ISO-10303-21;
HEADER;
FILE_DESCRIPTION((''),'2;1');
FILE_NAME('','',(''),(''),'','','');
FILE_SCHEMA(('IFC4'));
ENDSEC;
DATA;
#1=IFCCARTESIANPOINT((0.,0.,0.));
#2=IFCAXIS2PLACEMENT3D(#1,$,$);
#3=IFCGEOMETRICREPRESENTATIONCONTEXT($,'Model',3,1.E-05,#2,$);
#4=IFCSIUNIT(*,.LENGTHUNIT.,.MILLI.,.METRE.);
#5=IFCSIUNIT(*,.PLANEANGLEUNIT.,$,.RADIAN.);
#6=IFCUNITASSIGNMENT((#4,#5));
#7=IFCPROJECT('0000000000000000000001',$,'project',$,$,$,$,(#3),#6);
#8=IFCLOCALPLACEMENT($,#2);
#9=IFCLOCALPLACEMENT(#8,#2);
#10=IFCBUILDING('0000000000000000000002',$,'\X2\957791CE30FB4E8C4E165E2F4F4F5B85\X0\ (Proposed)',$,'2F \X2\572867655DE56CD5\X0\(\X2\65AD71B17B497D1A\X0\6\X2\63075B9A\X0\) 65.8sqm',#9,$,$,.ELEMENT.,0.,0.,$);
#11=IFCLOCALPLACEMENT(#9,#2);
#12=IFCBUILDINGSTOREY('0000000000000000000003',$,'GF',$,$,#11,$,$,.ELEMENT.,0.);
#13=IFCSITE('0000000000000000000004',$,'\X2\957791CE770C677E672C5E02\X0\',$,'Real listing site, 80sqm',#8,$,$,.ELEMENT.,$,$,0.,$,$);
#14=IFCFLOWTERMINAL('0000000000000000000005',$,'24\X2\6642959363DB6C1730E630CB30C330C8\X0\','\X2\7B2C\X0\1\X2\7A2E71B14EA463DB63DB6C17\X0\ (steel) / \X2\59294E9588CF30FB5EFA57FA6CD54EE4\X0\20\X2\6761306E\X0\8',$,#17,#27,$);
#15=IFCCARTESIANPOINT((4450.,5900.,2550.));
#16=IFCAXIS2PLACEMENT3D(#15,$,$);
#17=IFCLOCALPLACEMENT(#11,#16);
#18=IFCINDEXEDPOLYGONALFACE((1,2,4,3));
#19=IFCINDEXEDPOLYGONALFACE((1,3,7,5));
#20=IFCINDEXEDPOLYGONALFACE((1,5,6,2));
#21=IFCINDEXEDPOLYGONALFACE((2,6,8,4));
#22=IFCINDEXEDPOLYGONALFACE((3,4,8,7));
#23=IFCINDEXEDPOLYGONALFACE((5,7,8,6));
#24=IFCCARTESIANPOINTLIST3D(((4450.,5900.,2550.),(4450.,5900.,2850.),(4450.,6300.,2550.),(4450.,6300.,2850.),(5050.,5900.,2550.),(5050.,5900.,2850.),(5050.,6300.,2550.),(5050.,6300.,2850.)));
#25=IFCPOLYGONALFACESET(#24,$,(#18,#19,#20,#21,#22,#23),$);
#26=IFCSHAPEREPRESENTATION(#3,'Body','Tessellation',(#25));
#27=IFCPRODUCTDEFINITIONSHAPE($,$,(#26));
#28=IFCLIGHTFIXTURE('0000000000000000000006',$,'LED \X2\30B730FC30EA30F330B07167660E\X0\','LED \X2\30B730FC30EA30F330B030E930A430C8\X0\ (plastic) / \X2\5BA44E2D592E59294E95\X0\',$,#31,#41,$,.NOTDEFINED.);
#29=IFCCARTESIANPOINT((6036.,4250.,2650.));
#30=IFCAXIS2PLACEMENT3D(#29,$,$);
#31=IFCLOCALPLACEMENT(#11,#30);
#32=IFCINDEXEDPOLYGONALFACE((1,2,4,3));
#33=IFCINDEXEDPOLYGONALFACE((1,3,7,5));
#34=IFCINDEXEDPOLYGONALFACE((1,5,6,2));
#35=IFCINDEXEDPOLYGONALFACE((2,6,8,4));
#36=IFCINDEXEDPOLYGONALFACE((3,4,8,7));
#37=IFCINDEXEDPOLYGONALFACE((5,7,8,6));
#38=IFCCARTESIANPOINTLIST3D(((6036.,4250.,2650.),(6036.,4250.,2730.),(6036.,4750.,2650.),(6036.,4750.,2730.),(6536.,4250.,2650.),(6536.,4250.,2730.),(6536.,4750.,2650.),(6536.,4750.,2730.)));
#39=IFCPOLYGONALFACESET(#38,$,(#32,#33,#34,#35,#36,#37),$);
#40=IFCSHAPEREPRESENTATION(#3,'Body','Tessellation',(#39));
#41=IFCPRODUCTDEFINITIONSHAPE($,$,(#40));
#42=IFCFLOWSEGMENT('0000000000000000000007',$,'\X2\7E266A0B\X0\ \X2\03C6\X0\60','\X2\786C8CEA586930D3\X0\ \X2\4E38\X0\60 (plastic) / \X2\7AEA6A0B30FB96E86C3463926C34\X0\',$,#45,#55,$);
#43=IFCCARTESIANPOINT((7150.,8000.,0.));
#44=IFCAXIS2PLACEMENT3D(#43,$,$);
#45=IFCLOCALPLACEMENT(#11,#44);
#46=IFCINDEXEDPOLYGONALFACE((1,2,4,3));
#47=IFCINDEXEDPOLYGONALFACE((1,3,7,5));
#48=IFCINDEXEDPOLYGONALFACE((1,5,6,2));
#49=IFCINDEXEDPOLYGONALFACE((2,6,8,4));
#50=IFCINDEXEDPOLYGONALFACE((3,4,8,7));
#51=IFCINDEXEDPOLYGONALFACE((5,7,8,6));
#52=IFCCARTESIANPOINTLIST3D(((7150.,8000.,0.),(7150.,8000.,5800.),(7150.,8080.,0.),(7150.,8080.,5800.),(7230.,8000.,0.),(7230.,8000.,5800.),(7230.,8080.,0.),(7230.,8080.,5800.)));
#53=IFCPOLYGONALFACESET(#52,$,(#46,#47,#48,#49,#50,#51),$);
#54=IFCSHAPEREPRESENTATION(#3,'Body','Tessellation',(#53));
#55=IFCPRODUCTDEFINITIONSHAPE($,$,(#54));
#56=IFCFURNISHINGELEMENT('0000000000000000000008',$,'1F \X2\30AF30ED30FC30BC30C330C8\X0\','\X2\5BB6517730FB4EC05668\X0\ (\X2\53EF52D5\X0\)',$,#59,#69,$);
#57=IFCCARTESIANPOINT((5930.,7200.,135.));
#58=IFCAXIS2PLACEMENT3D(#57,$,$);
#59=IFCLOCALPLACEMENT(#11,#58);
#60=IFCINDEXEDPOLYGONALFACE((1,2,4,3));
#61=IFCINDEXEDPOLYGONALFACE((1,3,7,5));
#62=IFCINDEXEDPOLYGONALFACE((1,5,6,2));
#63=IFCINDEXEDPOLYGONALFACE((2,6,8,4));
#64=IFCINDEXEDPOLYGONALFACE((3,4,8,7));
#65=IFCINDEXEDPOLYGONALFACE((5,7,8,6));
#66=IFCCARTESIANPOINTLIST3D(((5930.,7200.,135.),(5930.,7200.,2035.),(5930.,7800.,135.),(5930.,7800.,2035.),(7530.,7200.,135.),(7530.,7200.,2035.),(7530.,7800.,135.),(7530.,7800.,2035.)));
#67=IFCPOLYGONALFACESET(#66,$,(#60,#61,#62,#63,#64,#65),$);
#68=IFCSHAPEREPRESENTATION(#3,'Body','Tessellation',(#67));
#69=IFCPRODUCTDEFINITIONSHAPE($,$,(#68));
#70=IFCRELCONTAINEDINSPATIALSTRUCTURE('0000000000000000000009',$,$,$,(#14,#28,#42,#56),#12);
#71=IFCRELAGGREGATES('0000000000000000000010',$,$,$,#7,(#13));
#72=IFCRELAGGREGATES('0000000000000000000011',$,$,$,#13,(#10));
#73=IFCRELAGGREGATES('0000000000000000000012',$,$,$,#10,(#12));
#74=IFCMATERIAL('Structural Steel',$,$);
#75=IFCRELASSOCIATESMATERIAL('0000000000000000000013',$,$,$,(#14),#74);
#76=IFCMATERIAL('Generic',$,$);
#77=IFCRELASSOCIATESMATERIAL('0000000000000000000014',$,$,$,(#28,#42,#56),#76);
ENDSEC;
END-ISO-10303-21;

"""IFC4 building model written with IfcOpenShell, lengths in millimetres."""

from ifc_helpers import new_model, si_unit, frame, frame_2d, origin, place, context, project, spatial, rectangle, extrude, material, element, save


model = new_model("IFC4")

# Units and contexts
model_context = context("Model", 3, precision=1e-05, world=origin())
ifc_project = project(units=[si_unit("LENGTHUNIT", "METRE", prefix="MILLI"), si_unit("PLANEANGLEUNIT", "RADIAN")], contexts=[model_context])

# Site, building, storey
site_placement = place(None, origin())
site = spatial("IfcSite", under=ifc_project, at=site_placement, Name="長野県松本市", ObjectType="Real listing site, 80sqm", CompositionType="ELEMENT", RefElevation=0.0)
building_placement = place(site_placement, origin())
building = spatial("IfcBuilding", under=site, at=building_placement, Name="長野・二世帯住宅 (Proposed)", ObjectType="2F 在来工法(断熱等級6指定) 65.8sqm", CompositionType="ELEMENT", ElevationOfRefHeight=0.0, ElevationOfTerrain=0.0)
storey_placement = place(building_placement, origin())
storey = spatial("IfcBuildingStorey", under=building, at=storey_placement, Name="GF", CompositionType="ELEMENT", Elevation=0.0)

# Shared definitions
ifc_material_1 = material(Name="Generic")

# Flow terminal
ifc_material_2 = material(Name="Structural Steel")
flow_terminal_placement = place(storey_placement, frame((4450.0, 5900.0, 2550.0)))
element("IfcFlowTerminal", 1, at=flow_terminal_placement, inside=storey, material=ifc_material_2, Name="24時間換気ユニット", Description="第1種熱交換換気 (steel) / 天井裏・建基法令20条の8", context=model_context, shape_type="SweptSolid", body=[
    extrude(rectangle(XDim=600.0, YDim=400.0, at=frame_2d((300.0, 200.0))), frame((4450.0, 5900.0, 2550.0)), (0.0, 0.0, 1.0), 300.0),
])

# Light fixture
light_fixture_placement = place(storey_placement, frame((6036.0, 4250.0, 2650.0)))
element("IfcLightFixture", 2, at=light_fixture_placement, inside=storey, material=ifc_material_1, Name="LED シーリング照明", Description="LED シーリングライト (plastic) / 室中央天井", PredefinedType="NOTDEFINED", context=model_context, shape_type="SweptSolid", body=[
    extrude(rectangle(XDim=500.0, YDim=500.0, at=frame_2d((250.0, 250.0))), frame((6036.0, 4250.0, 2650.0)), (0.0, 0.0, 1.0), 80.0),
])

# Flow segment
flow_segment_placement = place(storey_placement, frame((7150.0, 8000.0, 0.0)))
element("IfcFlowSegment", 3, at=flow_segment_placement, inside=storey, material=ifc_material_1, Name="縦樋 φ60", Description="硬質塩ビ 丸60 (plastic) / 竪樋・雨水排水", context=model_context, shape_type="SweptSolid", body=[
    extrude(rectangle(XDim=80.0, YDim=80.0, at=frame_2d((40.0, 40.0))), frame((7150.0, 8000.0, 0.0)), (0.0, 0.0, 1.0), 5800.0),
])

# Furnishing element
furnishing_placement = place(storey_placement, frame((5930.0, 7200.0, 135.0)))
element("IfcFurnishingElement", 4, at=furnishing_placement, inside=storey, material=ifc_material_1, Name="1F クローゼット", Description="家具・什器 (可動)", context=model_context, shape_type="SweptSolid", body=[
    extrude(rectangle(XDim=1600.0, YDim=600.0, at=frame_2d((800.0, 300.0))), frame((5930.0, 7200.0, 135.0)), (0.0, 0.0, 1.0), 1900.0),
])

save(model, "model.ifc")
